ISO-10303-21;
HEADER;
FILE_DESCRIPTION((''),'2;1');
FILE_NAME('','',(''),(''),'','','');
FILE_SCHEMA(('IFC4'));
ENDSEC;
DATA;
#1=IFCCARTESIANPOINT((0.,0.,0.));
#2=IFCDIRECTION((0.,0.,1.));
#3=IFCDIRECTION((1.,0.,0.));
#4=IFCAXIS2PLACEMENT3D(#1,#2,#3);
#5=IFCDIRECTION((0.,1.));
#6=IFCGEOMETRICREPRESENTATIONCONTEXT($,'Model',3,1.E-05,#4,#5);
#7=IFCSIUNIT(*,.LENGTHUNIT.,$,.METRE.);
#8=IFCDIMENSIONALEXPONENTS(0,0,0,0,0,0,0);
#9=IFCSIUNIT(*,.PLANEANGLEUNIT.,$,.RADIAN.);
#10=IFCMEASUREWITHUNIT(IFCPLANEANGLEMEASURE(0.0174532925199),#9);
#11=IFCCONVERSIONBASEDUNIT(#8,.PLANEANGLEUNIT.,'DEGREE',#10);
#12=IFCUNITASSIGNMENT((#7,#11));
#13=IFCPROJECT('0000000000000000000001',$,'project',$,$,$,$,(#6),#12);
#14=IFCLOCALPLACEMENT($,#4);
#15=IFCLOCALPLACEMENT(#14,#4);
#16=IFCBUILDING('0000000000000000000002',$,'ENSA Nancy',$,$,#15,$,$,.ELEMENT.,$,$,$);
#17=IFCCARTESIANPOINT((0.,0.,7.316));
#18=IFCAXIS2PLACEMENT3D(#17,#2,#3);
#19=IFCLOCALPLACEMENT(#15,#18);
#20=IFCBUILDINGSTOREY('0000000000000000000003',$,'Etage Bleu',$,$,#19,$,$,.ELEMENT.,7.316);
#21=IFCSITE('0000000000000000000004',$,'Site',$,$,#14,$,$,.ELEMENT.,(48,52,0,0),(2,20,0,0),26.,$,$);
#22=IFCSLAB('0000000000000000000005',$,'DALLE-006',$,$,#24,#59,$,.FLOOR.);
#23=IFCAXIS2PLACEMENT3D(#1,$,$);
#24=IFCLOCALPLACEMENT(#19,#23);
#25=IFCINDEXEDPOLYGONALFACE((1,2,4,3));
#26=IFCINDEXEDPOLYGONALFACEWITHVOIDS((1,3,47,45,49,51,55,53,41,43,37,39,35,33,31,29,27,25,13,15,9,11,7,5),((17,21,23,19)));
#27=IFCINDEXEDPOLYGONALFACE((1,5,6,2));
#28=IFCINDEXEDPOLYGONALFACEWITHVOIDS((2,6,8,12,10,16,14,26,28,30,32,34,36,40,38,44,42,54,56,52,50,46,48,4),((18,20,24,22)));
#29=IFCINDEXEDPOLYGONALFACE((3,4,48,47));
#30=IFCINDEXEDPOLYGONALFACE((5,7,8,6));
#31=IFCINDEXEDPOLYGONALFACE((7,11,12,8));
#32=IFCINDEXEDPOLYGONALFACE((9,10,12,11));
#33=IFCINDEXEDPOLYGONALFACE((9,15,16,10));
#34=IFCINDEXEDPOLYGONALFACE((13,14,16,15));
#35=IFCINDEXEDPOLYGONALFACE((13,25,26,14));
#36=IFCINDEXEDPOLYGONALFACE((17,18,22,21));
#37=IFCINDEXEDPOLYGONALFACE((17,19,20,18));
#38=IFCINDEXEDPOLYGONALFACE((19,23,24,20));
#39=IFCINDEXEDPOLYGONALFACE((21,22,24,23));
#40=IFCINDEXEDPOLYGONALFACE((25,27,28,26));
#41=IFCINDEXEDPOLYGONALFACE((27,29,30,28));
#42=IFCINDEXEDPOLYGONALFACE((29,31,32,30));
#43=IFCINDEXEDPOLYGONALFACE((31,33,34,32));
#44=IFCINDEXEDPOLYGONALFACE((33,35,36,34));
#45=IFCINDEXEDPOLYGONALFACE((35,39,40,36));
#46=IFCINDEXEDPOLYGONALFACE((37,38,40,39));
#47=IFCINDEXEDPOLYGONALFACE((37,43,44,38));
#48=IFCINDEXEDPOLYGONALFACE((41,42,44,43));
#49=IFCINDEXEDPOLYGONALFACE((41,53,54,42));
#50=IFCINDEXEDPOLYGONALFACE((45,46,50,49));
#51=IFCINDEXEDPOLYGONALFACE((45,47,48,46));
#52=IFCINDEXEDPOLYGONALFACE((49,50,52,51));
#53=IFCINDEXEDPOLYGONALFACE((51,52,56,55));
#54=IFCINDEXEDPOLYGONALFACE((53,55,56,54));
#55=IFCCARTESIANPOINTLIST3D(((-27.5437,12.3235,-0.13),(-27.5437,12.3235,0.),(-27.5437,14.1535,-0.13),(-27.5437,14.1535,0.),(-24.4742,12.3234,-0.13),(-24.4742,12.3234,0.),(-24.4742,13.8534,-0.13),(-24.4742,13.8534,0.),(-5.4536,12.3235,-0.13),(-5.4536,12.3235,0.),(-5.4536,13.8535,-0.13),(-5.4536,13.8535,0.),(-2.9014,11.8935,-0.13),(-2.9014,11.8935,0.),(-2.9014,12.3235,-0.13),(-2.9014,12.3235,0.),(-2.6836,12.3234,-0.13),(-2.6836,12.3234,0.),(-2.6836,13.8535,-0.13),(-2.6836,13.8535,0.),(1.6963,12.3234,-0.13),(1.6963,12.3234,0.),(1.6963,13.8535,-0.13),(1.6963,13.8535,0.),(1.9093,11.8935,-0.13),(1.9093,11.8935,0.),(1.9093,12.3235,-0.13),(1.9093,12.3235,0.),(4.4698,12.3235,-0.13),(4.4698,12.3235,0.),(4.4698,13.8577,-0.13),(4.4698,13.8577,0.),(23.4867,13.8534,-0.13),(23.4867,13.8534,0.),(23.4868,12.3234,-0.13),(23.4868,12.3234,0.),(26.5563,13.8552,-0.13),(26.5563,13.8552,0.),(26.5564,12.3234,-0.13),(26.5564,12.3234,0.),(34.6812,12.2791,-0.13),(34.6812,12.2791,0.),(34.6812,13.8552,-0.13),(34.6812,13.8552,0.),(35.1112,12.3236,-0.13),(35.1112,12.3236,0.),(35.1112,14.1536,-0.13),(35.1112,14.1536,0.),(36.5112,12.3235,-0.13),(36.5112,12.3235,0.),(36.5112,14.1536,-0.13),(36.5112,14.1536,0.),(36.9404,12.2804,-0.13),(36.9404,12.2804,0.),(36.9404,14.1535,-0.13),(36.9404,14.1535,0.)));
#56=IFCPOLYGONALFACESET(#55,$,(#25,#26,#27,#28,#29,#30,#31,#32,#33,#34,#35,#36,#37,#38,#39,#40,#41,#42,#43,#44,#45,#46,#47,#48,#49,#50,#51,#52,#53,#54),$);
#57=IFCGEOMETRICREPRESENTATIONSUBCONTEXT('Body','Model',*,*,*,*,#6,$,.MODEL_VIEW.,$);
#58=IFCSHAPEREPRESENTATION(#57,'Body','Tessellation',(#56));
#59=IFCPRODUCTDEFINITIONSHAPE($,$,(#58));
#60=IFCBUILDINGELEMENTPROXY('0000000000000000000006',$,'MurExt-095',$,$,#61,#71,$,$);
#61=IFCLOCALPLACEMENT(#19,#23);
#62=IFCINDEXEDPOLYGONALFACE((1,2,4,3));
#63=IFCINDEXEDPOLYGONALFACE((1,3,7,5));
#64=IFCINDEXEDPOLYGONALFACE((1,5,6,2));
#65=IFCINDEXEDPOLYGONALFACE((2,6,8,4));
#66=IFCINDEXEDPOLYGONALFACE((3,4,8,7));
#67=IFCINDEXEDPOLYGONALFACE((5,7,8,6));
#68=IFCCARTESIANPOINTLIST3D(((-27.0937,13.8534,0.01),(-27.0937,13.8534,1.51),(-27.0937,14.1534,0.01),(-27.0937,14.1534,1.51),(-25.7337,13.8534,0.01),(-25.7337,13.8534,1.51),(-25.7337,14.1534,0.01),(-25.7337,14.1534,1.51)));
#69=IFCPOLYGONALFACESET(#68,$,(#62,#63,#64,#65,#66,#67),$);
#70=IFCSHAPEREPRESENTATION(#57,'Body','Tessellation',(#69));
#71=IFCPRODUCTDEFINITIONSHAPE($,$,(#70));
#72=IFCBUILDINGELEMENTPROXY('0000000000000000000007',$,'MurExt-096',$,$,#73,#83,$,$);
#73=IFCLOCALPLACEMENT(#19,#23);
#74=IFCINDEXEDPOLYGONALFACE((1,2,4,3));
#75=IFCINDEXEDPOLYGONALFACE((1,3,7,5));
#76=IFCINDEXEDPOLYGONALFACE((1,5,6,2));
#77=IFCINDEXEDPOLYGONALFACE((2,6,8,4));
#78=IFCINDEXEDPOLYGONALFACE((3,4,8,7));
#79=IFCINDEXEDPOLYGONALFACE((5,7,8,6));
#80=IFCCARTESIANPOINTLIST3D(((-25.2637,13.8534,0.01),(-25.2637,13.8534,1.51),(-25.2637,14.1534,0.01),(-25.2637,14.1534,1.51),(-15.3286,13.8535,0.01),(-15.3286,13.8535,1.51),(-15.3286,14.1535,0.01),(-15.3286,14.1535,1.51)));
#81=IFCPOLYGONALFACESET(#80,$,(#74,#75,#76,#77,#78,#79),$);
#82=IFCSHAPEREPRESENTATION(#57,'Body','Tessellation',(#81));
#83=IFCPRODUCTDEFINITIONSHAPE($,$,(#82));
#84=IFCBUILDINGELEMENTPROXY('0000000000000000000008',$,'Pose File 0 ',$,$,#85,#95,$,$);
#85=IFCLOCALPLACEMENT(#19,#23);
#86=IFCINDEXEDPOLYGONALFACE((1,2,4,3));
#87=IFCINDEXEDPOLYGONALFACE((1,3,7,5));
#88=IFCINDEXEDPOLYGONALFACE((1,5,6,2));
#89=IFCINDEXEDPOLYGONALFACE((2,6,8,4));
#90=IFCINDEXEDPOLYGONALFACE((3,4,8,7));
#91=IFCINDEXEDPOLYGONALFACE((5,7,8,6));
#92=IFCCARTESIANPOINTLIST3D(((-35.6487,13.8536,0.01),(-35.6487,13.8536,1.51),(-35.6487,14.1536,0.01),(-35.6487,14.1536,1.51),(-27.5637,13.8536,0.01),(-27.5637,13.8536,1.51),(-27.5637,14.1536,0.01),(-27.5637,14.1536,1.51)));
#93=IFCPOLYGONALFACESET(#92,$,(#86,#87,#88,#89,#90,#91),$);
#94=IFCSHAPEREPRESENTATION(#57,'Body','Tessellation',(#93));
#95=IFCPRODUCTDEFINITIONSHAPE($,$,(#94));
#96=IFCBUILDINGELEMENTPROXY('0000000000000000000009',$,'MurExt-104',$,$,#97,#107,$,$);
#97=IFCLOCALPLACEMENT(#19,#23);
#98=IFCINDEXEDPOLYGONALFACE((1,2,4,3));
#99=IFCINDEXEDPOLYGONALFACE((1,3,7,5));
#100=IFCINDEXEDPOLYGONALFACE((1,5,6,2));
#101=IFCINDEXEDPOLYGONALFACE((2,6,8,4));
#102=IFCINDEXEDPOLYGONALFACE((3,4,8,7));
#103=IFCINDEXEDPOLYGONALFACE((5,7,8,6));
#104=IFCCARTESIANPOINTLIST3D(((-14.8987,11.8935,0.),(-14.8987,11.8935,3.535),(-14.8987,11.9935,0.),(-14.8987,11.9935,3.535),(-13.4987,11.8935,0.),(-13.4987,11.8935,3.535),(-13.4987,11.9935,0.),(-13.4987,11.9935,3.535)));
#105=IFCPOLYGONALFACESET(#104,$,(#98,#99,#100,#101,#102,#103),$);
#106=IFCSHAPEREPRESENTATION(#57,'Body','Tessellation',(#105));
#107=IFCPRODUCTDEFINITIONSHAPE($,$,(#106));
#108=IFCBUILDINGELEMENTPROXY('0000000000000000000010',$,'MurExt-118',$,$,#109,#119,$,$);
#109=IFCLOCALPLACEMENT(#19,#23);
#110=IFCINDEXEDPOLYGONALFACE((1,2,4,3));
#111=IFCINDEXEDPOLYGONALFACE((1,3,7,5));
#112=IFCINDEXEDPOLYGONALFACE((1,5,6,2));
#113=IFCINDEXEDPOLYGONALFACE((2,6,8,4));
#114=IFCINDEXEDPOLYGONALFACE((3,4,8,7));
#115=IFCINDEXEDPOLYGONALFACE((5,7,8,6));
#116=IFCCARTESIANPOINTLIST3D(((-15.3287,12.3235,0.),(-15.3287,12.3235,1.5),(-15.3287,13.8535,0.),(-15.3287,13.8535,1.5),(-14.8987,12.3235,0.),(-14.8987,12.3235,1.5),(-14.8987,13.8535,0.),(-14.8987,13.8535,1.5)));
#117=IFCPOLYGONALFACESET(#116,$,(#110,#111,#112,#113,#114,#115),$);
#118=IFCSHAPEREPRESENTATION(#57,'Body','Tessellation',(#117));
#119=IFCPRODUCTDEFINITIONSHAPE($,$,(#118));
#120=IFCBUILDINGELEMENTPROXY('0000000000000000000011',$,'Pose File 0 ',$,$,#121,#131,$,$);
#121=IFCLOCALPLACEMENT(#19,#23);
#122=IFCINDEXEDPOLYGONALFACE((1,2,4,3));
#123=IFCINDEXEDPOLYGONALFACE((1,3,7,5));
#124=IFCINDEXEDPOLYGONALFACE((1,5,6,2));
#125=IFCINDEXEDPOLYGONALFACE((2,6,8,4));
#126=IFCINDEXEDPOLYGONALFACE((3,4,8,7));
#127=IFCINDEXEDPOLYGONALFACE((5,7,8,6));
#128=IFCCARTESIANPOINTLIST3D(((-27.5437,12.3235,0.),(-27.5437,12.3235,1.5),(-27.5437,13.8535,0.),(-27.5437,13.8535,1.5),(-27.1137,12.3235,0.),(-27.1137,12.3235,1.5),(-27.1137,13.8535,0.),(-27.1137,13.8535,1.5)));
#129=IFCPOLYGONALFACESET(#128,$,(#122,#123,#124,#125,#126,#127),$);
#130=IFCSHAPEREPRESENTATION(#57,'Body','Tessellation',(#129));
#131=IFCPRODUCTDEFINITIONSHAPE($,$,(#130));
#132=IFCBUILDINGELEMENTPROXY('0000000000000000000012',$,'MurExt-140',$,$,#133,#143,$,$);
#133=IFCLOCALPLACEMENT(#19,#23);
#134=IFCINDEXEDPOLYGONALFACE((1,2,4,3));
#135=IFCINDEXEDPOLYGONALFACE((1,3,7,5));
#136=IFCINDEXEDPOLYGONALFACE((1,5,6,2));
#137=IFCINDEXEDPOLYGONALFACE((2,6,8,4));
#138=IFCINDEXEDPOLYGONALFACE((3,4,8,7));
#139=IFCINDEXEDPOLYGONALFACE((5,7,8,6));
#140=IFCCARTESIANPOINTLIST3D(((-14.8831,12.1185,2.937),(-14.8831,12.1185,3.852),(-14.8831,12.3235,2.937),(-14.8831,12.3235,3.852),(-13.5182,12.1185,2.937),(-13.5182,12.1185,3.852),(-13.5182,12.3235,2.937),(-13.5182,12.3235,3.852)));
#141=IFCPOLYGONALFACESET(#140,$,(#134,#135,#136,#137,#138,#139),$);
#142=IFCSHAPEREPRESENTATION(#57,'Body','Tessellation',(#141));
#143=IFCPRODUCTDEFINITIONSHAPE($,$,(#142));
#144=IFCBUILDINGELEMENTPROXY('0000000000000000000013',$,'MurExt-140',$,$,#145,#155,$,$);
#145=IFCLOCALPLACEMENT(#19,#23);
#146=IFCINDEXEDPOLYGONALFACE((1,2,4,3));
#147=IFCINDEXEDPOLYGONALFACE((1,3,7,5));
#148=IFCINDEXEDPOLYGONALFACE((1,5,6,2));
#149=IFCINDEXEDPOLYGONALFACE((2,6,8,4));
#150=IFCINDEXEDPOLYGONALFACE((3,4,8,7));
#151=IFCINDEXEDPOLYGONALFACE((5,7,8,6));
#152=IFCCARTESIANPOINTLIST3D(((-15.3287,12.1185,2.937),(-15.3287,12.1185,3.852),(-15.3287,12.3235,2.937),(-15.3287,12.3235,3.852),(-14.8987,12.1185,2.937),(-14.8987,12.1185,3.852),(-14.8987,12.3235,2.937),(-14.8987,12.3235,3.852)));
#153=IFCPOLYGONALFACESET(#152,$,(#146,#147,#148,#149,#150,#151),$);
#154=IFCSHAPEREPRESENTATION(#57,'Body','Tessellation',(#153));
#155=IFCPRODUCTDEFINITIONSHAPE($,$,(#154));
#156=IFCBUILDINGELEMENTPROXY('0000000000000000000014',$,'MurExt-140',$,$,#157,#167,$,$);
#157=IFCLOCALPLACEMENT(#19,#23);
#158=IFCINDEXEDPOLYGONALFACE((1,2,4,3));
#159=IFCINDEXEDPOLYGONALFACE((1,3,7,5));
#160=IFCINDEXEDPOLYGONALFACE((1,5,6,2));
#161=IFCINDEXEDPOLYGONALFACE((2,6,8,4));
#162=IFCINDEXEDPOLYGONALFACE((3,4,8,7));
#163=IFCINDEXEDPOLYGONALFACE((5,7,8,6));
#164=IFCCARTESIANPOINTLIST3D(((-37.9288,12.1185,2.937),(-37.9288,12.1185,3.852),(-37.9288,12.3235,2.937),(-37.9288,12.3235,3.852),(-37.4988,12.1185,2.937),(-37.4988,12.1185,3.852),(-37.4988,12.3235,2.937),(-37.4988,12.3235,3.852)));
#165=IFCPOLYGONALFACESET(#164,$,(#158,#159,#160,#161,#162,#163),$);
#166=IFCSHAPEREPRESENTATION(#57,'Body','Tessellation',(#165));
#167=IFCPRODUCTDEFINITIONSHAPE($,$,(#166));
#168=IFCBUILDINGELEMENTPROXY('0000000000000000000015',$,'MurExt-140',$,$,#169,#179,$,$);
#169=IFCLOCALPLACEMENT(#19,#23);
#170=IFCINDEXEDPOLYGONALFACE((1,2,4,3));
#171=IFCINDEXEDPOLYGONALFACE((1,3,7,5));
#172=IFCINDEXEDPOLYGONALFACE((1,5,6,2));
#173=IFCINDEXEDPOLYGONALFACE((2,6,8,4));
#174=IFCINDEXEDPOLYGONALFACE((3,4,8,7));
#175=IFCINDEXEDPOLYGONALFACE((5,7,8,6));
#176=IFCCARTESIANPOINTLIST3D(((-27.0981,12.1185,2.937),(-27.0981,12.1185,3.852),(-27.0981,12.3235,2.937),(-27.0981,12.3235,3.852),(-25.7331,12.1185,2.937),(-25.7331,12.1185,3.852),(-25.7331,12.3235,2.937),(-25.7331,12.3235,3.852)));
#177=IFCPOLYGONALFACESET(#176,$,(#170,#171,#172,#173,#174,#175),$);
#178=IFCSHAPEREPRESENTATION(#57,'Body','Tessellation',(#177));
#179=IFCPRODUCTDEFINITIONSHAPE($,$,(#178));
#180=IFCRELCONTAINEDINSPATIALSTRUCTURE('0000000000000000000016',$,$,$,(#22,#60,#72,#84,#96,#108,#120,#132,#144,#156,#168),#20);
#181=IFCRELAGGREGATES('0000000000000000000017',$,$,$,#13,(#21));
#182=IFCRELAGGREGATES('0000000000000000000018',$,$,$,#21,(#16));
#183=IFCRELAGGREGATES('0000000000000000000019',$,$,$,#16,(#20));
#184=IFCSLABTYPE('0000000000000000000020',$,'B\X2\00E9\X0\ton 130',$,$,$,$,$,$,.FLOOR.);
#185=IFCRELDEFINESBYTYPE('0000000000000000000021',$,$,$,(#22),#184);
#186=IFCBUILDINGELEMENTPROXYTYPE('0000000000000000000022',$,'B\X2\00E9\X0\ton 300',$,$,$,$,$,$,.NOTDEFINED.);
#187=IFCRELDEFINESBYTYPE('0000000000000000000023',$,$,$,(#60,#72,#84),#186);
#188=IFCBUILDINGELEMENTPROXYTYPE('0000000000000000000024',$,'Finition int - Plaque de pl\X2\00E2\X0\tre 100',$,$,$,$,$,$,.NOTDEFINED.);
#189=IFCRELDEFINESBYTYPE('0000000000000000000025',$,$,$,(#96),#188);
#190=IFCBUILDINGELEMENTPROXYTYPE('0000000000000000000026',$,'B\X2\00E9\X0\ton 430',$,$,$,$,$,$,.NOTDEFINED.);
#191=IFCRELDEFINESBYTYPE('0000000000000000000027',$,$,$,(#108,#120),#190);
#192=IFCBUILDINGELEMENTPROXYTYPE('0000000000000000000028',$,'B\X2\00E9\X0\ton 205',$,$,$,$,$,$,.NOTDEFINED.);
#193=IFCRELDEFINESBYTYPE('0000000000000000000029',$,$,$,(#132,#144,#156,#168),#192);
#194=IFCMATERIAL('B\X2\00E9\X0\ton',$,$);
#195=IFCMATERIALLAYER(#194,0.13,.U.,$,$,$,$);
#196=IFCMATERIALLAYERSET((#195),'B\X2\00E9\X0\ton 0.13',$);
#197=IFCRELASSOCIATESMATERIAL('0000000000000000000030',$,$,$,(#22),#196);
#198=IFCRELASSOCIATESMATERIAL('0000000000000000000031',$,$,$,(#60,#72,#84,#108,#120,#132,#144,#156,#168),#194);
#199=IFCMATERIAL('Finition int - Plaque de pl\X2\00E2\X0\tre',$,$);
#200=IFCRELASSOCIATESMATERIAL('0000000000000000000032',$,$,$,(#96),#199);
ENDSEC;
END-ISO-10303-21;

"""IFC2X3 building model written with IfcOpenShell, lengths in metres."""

from ifc_helpers import new_model, entity, si_unit, converted_unit, direction, frame, origin_with_axes, place, context, subcontext, project, spatial, polyline, outline, extrude, material, layer, layer_set, layer_usage, type_object, element, save


model = new_model("IFC2X3")

# Units and contexts
model_context = context("Model", 3, precision=1e-05, world=origin_with_axes(), true_north=direction((0.0, 1.0)))
body_context = subcontext(model_context, "Body", "Model", "MODEL_VIEW")
ifc_project = project(units=[si_unit("LENGTHUNIT", "METRE"), converted_unit("PLANEANGLEUNIT", "DEGREE", entity("IfcPlaneAngleMeasure", 0.0174532925199), si_unit("PLANEANGLEUNIT", "RADIAN"), dimensions=[0, 0, 0, 0, 0, 0, 0])], contexts=[model_context])

# Site, building, storey
site_placement = place(None, origin_with_axes())
site = spatial("IfcSite", under=ifc_project, at=site_placement, Name="Site", CompositionType="ELEMENT", RefLatitude=(48, 52, 0, 0), RefLongitude=(2, 20, 0, 0), RefElevation=26.0)
building_placement = place(site_placement, origin_with_axes())
building = spatial("IfcBuilding", under=site, at=building_placement, Name="ENSA Nancy", CompositionType="ELEMENT")
storey_placement = place(building_placement, frame((0.0, 0.0, 7.316), z_axis=(0.0, 0.0, 1.0), x_axis=(1.0, 0.0, 0.0)))
storey = spatial("IfcBuildingStorey", under=building, at=storey_placement, Name="Etage Bleu", CompositionType="ELEMENT", Elevation=7.316)

# Slab, opening
ifc_material_1 = material(Name="Béton")
ifc_layer = layer(ifc_material_1, 0.13, ventilated="UNKNOWN")
ifc_layer_set = layer_set([ifc_layer], Name="Béton 0.13")
ifc_layer_usage = layer_usage(ifc_layer_set, "AXIS3", "NEGATIVE", 0.13)
slab_type = type_object("IfcSlabType", Name="Béton 130", PredefinedType="FLOOR")
slab_placement = place(storey_placement, frame((-27.5437, 13.8535, 0.0), z_axis=(0.0, 0.0, 1.0), x_axis=(1.0, 0.0, 0.0)))
slab = element("IfcSlab", 1, at=slab_placement, inside=storey, type_object=slab_type, material=ifc_layer_usage, Name="DALLE-006", PredefinedType="FLOOR", context=body_context, shape_type="SweptSolid", body=[
    extrude(outline(polyline([(0.0, -1.53), (3.0695, -1.53), (3.0695, 0.0), (22.0902, 0.0), (22.0902, -1.53), (24.6423, -1.53), (24.6423, -1.96), (29.453, -1.96), (29.453, -1.53), (32.0135, -1.53), (32.0135, 0.0042), (51.0305, 0.0), (51.0305, -1.53), (54.1001, -1.53), (54.1, 0.0018), (62.2249, 0.0018), (62.2249, -1.5744), (64.4841, -1.5731), (64.4841, 0.3), (64.0549, 0.3001), (64.0549, -1.53), (62.6549, -1.5299), (62.6549, 0.3001), (0.0, 0.3), (0.0, -1.53)])), frame((0.0, 0.0, -0.13), z_axis=(0.0, 0.0, 1.0), x_axis=(1.0, 0.0, 0.0)), (0.0, 0.0, 1.0), 0.13),
])
opening_placement = place(slab_placement, frame((24.8601, 0.0001, 0.0), z_axis=(0.0, 0.0, 1.0), x_axis=(0.0, -1.0, 0.0)))
element("IfcOpeningElement", 2, at=opening_placement, cuts=slab, context=body_context, shape_type="SweptSolid", body=[
    extrude(outline(polyline([(0.0, 0.0), (1.5301, 0.0), (1.5301, 4.3799), (0.0, 4.3799), (0.0, 0.0)])), frame((0.0, 0.0, -0.13), z_axis=(0.0, 0.0, 1.0), x_axis=(1.0, 0.0, 0.0)), (0.0, 0.0, 1.0), 0.13),
])

# Building element proxies
building_element_proxy_type_1 = type_object("IfcBuildingElementProxyType", Name="Béton 300", PredefinedType="NOTDEFINED")
proxy_1_placement = place(storey_placement, frame((-27.0937, 13.8534, 0.01), z_axis=(0.0, 0.0, 1.0), x_axis=(1.0, 0.0, 0.0)))
element("IfcBuildingElementProxy", 3, at=proxy_1_placement, inside=storey, type_object=building_element_proxy_type_1, material=ifc_material_1, Name="MurExt-095", context=body_context, shape_type="SweptSolid", body=[
    extrude(outline(polyline([(0.0, 0.0), (1.36, 0.0), (1.36, 0.3), (0.0, 0.3), (0.0, 0.0)])), origin_with_axes(), (0.0, 0.0, 1.0), 1.5),
])
proxy_2_placement = place(storey_placement, frame((-25.2637, 13.8534, 0.01), z_axis=(0.0, 0.0, 1.0), x_axis=(1.0, 0.000009, 0.0)))
element("IfcBuildingElementProxy", 4, at=proxy_2_placement, inside=storey, type_object=building_element_proxy_type_1, material=ifc_material_1, Name="MurExt-096", context=body_context, shape_type="SweptSolid", body=[
    extrude(outline(polyline([(0.0, 0.0), (9.9351, 0.0), (9.9351, 0.3), (0.0, 0.3), (0.0, 0.0)])), origin_with_axes(), (0.0, 0.0, 1.0), 1.5),
])
proxy_3_placement = place(storey_placement, frame((-27.5637, 13.8536, 0.01), z_axis=(0.0, 0.0, 1.0), x_axis=(-1.0, 0.0, 0.0)))
element("IfcBuildingElementProxy", 5, at=proxy_3_placement, inside=storey, type_object=building_element_proxy_type_1, material=ifc_material_1, Name="Pose File 0 ", context=body_context, shape_type="SweptSolid", body=[
    extrude(outline(polyline([(0.0, -0.3), (8.085, -0.3), (8.085, 0.0), (0.0, 0.0), (0.0, -0.3)])), origin_with_axes(), (0.0, 0.0, 1.0), 1.5),
])
ifc_material_2 = material(Name="Finition int - Plaque de plâtre")
building_element_proxy_type_2 = type_object("IfcBuildingElementProxyType", Name="Finition int - Plaque de plâtre 100", PredefinedType="NOTDEFINED")
proxy_4_placement = place(storey_placement, frame((-14.8987, 11.8935, 0.0), z_axis=(0.0, 0.0, 1.0), x_axis=(1.0, 0.0, 0.0)))
element("IfcBuildingElementProxy", 6, at=proxy_4_placement, inside=storey, type_object=building_element_proxy_type_2, material=ifc_material_2, Name="MurExt-104", context=body_context, shape_type="SweptSolid", body=[
    extrude(outline(polyline([(0.0, 0.0), (1.4, 0.0), (1.4, 0.1), (0.0, 0.1), (0.0, 0.0)])), origin_with_axes(), (0.0, 0.0, 1.0), 3.535),
])
building_element_proxy_type_3 = type_object("IfcBuildingElementProxyType", Name="Béton 430", PredefinedType="NOTDEFINED")
proxy_5_placement = place(storey_placement, frame((-15.3287, 13.8535, 0.0), z_axis=(0.0, 0.0, 1.0), x_axis=(0.0, -1.0, 0.0)))
element("IfcBuildingElementProxy", 7, at=proxy_5_placement, inside=storey, type_object=building_element_proxy_type_3, material=ifc_material_1, Name="MurExt-118", context=body_context, shape_type="SweptSolid", body=[
    extrude(outline(polyline([(0.0, 0.0), (1.53, 0.0), (1.53, 0.43), (0.0, 0.43), (0.0, 0.0)])), origin_with_axes(), (0.0, 0.0, 1.0), 1.5),
])
proxy_6_placement = place(storey_placement, frame((-27.1137, 13.8535, 0.0), z_axis=(0.0, 0.0, 1.0), x_axis=(0.0, -1.0, 0.0)))
element("IfcBuildingElementProxy", 8, at=proxy_6_placement, inside=storey, type_object=building_element_proxy_type_3, material=ifc_material_1, Name="Pose File 0 ", context=body_context, shape_type="SweptSolid", body=[
    extrude(outline(polyline([(0.0, -0.43), (1.53, -0.43), (1.53, 0.0), (0.0, 0.0), (0.0, -0.43)])), origin_with_axes(), (0.0, 0.0, 1.0), 1.5),
])
building_element_proxy_type_4 = type_object("IfcBuildingElementProxyType", Name="Béton 205", PredefinedType="NOTDEFINED")
proxy_7_placement = place(storey_placement, frame((-14.8831, 12.3235, 2.937), z_axis=(0.0, 0.0, 1.0), x_axis=(1.0, -0.000005, 0.0)))
element("IfcBuildingElementProxy", 9, at=proxy_7_placement, inside=storey, type_object=building_element_proxy_type_4, material=ifc_material_1, Name="MurExt-140", context=body_context, shape_type="SweptSolid", body=[
    extrude(outline(polyline([(0.0, -0.205), (1.3649, -0.205), (1.3649, 0.0), (0.0, 0.0), (0.0, -0.205)])), origin_with_axes(), (0.0, 0.0, 1.0), 0.915),
])
for number, where, z_axis, x_axis, name in (
    (10, (-15.3287, 12.3235, 2.937), (0.0, 0.0, 1.0), (1.0, 0.0, 0.0), "MurExt-140"),
    (11, (-37.9288, 12.3235, 2.937), (0.0, 0.0, 1.0), (1.0, 0.0, 0.0), "MurExt-140"),
):
    element("IfcBuildingElementProxy", number, at=place(storey_placement, frame(where, z_axis=z_axis, x_axis=x_axis)), inside=storey, type_object=building_element_proxy_type_4, material=ifc_material_1, Name=name, context=body_context, shape_type="SweptSolid", body=[
        extrude(outline(polyline([(0.0, -0.205), (0.43, -0.205), (0.43, 0.0), (0.0, 0.0), (0.0, -0.205)])), origin_with_axes(), (0.0, 0.0, 1.0), 0.915),
    ])
proxy_8_placement = place(storey_placement, frame((-27.0981, 12.3235, 2.937), z_axis=(0.0, 0.0, 1.0), x_axis=(1.0, -0.000005, 0.0)))
element("IfcBuildingElementProxy", 12, at=proxy_8_placement, inside=storey, type_object=building_element_proxy_type_4, material=ifc_material_1, Name="MurExt-140", context=body_context, shape_type="SweptSolid", body=[
    extrude(outline(polyline([(0.0, -0.205), (1.3649, -0.205), (1.3649, 0.0), (0.0, 0.0), (0.0, -0.205)])), origin_with_axes(), (0.0, 0.0, 1.0), 0.915),
])

save(model, "model.ifc")
